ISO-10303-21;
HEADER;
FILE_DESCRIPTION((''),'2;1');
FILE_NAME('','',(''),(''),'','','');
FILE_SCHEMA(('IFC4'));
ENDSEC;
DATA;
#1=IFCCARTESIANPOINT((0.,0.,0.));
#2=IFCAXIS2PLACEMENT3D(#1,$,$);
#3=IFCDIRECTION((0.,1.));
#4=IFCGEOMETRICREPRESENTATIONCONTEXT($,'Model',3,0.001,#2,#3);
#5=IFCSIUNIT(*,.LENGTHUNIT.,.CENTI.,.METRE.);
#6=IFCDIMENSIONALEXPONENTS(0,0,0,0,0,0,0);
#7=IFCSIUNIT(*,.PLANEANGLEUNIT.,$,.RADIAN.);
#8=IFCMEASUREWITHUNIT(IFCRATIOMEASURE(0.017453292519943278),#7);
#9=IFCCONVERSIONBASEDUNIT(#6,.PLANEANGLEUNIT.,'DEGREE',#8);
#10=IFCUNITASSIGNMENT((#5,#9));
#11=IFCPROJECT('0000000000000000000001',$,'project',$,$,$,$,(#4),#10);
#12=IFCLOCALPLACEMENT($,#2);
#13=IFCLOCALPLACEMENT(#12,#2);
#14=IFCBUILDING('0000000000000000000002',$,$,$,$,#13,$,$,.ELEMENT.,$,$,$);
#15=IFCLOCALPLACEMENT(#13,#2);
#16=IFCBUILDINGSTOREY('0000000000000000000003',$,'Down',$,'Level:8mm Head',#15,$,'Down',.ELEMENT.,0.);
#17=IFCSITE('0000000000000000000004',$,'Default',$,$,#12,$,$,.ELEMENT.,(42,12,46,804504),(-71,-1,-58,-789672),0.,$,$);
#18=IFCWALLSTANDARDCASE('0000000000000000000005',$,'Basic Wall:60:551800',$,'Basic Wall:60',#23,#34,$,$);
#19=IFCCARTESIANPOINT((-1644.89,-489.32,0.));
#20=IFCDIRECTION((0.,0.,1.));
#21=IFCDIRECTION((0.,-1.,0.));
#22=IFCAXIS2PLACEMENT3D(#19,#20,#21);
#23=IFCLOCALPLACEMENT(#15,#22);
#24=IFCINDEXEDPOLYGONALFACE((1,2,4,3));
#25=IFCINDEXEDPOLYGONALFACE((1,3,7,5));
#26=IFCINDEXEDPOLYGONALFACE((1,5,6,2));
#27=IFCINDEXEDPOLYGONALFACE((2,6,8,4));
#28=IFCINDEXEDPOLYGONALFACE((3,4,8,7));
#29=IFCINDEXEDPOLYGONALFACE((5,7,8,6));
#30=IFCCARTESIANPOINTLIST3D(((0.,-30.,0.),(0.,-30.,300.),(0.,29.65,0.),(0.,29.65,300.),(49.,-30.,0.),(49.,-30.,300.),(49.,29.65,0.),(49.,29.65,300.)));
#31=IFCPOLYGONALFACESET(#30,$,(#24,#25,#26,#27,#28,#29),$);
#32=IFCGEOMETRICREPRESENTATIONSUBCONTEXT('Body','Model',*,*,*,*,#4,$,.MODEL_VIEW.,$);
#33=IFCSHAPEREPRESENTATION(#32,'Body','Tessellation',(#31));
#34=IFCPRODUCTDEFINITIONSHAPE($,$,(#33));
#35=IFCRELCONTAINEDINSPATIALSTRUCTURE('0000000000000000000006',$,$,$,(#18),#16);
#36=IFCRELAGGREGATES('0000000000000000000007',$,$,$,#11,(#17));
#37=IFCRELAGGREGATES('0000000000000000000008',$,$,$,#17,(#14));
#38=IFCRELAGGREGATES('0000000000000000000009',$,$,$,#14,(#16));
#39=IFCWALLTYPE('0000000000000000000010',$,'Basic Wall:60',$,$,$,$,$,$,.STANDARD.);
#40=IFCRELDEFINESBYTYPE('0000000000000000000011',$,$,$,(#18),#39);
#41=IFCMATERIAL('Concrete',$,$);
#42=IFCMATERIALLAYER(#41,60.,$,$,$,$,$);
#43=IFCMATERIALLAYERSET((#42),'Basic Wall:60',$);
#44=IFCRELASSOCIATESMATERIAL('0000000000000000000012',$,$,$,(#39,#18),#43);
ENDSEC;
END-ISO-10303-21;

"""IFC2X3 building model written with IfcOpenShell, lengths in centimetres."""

from ifc_helpers import new_model, entity, si_unit, converted_unit, direction, frame, frame_2d, origin, place, context, subcontext, project, spatial, polyline, rectangle, extrude, clip, bounded_halfspace, material, layer, layer_set, layer_usage, type_object, element, save


model = new_model("IFC2X3")

# Units and contexts
model_context = context("Model", 3, precision=0.001, world=origin(), true_north=direction((0.0, 1.0)))
body_context = subcontext(model_context, "Body", "Model", "MODEL_VIEW")
ifc_project = project(units=[si_unit("LENGTHUNIT", "METRE", prefix="CENTI"), converted_unit("PLANEANGLEUNIT", "DEGREE", entity("IfcRatioMeasure", 0.017453292519943278), si_unit("PLANEANGLEUNIT", "RADIAN"), dimensions=[0, 0, 0, 0, 0, 0, 0])], contexts=[model_context])

# Site, building, storey
site_placement = place(None, origin())
site = spatial("IfcSite", under=ifc_project, at=site_placement, Name="Default", CompositionType="ELEMENT", RefLatitude=(42, 12, 46, 804504), RefLongitude=(-71, -1, -58, -789672), RefElevation=0.0)
building_placement = place(site_placement, origin())
building = spatial("IfcBuilding", under=site, at=building_placement, CompositionType="ELEMENT")
storey_placement = place(building_placement, origin())
storey = spatial("IfcBuildingStorey", under=building, at=storey_placement, Name="Down", ObjectType="Level:8mm Head", LongName="Down", CompositionType="ELEMENT", Elevation=0.0)

# Shared definitions
ifc_material = material(Name="Concrete")

# Wall
ifc_layer_1 = layer(ifc_material, 60.0)
ifc_layer_set_1 = layer_set([ifc_layer_1], Name="Basic Wall:60")
ifc_layer_usage_1 = layer_usage(ifc_layer_set_1, "AXIS2", "NEGATIVE", 30.0)
wall_type_1 = type_object("IfcWallType", Name="Basic Wall:60", PredefinedType="STANDARD", material=ifc_layer_set_1)
wall_1_placement = place(storey_placement, frame((-1644.89, -489.32, 0.0), z_axis=(0.0, 0.0, 1.0), x_axis=(0.0, -1.0, 0.0)))
element("IfcWallStandardCase", 1, at=wall_1_placement, inside=storey, type_object=wall_type_1, material=ifc_layer_usage_1, Name="Basic Wall:60:551800", ObjectType="Basic Wall:60", context=body_context, shape_type="Clipping", body=[
    clip(extrude(rectangle(XDim=49.0, YDim=60.0, at=frame_2d((24.5, 0.0), x_axis=(-1.0, 0.0))), origin(), (0.0, 0.0, 1.0), 300.0), bounded_halfspace(frame((0.0, 29.65, 0.0), z_axis=(0.0, -1.0, 0.0), x_axis=(1.0, 0.0, 0.0)), True, frame((0.0, 29.65, 0.0), z_axis=(0.0, -1.0, 0.0), x_axis=(1.0, 0.0, 0.0)), polyline([(0.0, 0.0), (25.0, 0.0), (49.0, 0.0), (49.0, 300.0), (25.0, 300.0), (0.0, 300.0), (0.0, 0.0)]))),
])

save(model, "model.ifc")
